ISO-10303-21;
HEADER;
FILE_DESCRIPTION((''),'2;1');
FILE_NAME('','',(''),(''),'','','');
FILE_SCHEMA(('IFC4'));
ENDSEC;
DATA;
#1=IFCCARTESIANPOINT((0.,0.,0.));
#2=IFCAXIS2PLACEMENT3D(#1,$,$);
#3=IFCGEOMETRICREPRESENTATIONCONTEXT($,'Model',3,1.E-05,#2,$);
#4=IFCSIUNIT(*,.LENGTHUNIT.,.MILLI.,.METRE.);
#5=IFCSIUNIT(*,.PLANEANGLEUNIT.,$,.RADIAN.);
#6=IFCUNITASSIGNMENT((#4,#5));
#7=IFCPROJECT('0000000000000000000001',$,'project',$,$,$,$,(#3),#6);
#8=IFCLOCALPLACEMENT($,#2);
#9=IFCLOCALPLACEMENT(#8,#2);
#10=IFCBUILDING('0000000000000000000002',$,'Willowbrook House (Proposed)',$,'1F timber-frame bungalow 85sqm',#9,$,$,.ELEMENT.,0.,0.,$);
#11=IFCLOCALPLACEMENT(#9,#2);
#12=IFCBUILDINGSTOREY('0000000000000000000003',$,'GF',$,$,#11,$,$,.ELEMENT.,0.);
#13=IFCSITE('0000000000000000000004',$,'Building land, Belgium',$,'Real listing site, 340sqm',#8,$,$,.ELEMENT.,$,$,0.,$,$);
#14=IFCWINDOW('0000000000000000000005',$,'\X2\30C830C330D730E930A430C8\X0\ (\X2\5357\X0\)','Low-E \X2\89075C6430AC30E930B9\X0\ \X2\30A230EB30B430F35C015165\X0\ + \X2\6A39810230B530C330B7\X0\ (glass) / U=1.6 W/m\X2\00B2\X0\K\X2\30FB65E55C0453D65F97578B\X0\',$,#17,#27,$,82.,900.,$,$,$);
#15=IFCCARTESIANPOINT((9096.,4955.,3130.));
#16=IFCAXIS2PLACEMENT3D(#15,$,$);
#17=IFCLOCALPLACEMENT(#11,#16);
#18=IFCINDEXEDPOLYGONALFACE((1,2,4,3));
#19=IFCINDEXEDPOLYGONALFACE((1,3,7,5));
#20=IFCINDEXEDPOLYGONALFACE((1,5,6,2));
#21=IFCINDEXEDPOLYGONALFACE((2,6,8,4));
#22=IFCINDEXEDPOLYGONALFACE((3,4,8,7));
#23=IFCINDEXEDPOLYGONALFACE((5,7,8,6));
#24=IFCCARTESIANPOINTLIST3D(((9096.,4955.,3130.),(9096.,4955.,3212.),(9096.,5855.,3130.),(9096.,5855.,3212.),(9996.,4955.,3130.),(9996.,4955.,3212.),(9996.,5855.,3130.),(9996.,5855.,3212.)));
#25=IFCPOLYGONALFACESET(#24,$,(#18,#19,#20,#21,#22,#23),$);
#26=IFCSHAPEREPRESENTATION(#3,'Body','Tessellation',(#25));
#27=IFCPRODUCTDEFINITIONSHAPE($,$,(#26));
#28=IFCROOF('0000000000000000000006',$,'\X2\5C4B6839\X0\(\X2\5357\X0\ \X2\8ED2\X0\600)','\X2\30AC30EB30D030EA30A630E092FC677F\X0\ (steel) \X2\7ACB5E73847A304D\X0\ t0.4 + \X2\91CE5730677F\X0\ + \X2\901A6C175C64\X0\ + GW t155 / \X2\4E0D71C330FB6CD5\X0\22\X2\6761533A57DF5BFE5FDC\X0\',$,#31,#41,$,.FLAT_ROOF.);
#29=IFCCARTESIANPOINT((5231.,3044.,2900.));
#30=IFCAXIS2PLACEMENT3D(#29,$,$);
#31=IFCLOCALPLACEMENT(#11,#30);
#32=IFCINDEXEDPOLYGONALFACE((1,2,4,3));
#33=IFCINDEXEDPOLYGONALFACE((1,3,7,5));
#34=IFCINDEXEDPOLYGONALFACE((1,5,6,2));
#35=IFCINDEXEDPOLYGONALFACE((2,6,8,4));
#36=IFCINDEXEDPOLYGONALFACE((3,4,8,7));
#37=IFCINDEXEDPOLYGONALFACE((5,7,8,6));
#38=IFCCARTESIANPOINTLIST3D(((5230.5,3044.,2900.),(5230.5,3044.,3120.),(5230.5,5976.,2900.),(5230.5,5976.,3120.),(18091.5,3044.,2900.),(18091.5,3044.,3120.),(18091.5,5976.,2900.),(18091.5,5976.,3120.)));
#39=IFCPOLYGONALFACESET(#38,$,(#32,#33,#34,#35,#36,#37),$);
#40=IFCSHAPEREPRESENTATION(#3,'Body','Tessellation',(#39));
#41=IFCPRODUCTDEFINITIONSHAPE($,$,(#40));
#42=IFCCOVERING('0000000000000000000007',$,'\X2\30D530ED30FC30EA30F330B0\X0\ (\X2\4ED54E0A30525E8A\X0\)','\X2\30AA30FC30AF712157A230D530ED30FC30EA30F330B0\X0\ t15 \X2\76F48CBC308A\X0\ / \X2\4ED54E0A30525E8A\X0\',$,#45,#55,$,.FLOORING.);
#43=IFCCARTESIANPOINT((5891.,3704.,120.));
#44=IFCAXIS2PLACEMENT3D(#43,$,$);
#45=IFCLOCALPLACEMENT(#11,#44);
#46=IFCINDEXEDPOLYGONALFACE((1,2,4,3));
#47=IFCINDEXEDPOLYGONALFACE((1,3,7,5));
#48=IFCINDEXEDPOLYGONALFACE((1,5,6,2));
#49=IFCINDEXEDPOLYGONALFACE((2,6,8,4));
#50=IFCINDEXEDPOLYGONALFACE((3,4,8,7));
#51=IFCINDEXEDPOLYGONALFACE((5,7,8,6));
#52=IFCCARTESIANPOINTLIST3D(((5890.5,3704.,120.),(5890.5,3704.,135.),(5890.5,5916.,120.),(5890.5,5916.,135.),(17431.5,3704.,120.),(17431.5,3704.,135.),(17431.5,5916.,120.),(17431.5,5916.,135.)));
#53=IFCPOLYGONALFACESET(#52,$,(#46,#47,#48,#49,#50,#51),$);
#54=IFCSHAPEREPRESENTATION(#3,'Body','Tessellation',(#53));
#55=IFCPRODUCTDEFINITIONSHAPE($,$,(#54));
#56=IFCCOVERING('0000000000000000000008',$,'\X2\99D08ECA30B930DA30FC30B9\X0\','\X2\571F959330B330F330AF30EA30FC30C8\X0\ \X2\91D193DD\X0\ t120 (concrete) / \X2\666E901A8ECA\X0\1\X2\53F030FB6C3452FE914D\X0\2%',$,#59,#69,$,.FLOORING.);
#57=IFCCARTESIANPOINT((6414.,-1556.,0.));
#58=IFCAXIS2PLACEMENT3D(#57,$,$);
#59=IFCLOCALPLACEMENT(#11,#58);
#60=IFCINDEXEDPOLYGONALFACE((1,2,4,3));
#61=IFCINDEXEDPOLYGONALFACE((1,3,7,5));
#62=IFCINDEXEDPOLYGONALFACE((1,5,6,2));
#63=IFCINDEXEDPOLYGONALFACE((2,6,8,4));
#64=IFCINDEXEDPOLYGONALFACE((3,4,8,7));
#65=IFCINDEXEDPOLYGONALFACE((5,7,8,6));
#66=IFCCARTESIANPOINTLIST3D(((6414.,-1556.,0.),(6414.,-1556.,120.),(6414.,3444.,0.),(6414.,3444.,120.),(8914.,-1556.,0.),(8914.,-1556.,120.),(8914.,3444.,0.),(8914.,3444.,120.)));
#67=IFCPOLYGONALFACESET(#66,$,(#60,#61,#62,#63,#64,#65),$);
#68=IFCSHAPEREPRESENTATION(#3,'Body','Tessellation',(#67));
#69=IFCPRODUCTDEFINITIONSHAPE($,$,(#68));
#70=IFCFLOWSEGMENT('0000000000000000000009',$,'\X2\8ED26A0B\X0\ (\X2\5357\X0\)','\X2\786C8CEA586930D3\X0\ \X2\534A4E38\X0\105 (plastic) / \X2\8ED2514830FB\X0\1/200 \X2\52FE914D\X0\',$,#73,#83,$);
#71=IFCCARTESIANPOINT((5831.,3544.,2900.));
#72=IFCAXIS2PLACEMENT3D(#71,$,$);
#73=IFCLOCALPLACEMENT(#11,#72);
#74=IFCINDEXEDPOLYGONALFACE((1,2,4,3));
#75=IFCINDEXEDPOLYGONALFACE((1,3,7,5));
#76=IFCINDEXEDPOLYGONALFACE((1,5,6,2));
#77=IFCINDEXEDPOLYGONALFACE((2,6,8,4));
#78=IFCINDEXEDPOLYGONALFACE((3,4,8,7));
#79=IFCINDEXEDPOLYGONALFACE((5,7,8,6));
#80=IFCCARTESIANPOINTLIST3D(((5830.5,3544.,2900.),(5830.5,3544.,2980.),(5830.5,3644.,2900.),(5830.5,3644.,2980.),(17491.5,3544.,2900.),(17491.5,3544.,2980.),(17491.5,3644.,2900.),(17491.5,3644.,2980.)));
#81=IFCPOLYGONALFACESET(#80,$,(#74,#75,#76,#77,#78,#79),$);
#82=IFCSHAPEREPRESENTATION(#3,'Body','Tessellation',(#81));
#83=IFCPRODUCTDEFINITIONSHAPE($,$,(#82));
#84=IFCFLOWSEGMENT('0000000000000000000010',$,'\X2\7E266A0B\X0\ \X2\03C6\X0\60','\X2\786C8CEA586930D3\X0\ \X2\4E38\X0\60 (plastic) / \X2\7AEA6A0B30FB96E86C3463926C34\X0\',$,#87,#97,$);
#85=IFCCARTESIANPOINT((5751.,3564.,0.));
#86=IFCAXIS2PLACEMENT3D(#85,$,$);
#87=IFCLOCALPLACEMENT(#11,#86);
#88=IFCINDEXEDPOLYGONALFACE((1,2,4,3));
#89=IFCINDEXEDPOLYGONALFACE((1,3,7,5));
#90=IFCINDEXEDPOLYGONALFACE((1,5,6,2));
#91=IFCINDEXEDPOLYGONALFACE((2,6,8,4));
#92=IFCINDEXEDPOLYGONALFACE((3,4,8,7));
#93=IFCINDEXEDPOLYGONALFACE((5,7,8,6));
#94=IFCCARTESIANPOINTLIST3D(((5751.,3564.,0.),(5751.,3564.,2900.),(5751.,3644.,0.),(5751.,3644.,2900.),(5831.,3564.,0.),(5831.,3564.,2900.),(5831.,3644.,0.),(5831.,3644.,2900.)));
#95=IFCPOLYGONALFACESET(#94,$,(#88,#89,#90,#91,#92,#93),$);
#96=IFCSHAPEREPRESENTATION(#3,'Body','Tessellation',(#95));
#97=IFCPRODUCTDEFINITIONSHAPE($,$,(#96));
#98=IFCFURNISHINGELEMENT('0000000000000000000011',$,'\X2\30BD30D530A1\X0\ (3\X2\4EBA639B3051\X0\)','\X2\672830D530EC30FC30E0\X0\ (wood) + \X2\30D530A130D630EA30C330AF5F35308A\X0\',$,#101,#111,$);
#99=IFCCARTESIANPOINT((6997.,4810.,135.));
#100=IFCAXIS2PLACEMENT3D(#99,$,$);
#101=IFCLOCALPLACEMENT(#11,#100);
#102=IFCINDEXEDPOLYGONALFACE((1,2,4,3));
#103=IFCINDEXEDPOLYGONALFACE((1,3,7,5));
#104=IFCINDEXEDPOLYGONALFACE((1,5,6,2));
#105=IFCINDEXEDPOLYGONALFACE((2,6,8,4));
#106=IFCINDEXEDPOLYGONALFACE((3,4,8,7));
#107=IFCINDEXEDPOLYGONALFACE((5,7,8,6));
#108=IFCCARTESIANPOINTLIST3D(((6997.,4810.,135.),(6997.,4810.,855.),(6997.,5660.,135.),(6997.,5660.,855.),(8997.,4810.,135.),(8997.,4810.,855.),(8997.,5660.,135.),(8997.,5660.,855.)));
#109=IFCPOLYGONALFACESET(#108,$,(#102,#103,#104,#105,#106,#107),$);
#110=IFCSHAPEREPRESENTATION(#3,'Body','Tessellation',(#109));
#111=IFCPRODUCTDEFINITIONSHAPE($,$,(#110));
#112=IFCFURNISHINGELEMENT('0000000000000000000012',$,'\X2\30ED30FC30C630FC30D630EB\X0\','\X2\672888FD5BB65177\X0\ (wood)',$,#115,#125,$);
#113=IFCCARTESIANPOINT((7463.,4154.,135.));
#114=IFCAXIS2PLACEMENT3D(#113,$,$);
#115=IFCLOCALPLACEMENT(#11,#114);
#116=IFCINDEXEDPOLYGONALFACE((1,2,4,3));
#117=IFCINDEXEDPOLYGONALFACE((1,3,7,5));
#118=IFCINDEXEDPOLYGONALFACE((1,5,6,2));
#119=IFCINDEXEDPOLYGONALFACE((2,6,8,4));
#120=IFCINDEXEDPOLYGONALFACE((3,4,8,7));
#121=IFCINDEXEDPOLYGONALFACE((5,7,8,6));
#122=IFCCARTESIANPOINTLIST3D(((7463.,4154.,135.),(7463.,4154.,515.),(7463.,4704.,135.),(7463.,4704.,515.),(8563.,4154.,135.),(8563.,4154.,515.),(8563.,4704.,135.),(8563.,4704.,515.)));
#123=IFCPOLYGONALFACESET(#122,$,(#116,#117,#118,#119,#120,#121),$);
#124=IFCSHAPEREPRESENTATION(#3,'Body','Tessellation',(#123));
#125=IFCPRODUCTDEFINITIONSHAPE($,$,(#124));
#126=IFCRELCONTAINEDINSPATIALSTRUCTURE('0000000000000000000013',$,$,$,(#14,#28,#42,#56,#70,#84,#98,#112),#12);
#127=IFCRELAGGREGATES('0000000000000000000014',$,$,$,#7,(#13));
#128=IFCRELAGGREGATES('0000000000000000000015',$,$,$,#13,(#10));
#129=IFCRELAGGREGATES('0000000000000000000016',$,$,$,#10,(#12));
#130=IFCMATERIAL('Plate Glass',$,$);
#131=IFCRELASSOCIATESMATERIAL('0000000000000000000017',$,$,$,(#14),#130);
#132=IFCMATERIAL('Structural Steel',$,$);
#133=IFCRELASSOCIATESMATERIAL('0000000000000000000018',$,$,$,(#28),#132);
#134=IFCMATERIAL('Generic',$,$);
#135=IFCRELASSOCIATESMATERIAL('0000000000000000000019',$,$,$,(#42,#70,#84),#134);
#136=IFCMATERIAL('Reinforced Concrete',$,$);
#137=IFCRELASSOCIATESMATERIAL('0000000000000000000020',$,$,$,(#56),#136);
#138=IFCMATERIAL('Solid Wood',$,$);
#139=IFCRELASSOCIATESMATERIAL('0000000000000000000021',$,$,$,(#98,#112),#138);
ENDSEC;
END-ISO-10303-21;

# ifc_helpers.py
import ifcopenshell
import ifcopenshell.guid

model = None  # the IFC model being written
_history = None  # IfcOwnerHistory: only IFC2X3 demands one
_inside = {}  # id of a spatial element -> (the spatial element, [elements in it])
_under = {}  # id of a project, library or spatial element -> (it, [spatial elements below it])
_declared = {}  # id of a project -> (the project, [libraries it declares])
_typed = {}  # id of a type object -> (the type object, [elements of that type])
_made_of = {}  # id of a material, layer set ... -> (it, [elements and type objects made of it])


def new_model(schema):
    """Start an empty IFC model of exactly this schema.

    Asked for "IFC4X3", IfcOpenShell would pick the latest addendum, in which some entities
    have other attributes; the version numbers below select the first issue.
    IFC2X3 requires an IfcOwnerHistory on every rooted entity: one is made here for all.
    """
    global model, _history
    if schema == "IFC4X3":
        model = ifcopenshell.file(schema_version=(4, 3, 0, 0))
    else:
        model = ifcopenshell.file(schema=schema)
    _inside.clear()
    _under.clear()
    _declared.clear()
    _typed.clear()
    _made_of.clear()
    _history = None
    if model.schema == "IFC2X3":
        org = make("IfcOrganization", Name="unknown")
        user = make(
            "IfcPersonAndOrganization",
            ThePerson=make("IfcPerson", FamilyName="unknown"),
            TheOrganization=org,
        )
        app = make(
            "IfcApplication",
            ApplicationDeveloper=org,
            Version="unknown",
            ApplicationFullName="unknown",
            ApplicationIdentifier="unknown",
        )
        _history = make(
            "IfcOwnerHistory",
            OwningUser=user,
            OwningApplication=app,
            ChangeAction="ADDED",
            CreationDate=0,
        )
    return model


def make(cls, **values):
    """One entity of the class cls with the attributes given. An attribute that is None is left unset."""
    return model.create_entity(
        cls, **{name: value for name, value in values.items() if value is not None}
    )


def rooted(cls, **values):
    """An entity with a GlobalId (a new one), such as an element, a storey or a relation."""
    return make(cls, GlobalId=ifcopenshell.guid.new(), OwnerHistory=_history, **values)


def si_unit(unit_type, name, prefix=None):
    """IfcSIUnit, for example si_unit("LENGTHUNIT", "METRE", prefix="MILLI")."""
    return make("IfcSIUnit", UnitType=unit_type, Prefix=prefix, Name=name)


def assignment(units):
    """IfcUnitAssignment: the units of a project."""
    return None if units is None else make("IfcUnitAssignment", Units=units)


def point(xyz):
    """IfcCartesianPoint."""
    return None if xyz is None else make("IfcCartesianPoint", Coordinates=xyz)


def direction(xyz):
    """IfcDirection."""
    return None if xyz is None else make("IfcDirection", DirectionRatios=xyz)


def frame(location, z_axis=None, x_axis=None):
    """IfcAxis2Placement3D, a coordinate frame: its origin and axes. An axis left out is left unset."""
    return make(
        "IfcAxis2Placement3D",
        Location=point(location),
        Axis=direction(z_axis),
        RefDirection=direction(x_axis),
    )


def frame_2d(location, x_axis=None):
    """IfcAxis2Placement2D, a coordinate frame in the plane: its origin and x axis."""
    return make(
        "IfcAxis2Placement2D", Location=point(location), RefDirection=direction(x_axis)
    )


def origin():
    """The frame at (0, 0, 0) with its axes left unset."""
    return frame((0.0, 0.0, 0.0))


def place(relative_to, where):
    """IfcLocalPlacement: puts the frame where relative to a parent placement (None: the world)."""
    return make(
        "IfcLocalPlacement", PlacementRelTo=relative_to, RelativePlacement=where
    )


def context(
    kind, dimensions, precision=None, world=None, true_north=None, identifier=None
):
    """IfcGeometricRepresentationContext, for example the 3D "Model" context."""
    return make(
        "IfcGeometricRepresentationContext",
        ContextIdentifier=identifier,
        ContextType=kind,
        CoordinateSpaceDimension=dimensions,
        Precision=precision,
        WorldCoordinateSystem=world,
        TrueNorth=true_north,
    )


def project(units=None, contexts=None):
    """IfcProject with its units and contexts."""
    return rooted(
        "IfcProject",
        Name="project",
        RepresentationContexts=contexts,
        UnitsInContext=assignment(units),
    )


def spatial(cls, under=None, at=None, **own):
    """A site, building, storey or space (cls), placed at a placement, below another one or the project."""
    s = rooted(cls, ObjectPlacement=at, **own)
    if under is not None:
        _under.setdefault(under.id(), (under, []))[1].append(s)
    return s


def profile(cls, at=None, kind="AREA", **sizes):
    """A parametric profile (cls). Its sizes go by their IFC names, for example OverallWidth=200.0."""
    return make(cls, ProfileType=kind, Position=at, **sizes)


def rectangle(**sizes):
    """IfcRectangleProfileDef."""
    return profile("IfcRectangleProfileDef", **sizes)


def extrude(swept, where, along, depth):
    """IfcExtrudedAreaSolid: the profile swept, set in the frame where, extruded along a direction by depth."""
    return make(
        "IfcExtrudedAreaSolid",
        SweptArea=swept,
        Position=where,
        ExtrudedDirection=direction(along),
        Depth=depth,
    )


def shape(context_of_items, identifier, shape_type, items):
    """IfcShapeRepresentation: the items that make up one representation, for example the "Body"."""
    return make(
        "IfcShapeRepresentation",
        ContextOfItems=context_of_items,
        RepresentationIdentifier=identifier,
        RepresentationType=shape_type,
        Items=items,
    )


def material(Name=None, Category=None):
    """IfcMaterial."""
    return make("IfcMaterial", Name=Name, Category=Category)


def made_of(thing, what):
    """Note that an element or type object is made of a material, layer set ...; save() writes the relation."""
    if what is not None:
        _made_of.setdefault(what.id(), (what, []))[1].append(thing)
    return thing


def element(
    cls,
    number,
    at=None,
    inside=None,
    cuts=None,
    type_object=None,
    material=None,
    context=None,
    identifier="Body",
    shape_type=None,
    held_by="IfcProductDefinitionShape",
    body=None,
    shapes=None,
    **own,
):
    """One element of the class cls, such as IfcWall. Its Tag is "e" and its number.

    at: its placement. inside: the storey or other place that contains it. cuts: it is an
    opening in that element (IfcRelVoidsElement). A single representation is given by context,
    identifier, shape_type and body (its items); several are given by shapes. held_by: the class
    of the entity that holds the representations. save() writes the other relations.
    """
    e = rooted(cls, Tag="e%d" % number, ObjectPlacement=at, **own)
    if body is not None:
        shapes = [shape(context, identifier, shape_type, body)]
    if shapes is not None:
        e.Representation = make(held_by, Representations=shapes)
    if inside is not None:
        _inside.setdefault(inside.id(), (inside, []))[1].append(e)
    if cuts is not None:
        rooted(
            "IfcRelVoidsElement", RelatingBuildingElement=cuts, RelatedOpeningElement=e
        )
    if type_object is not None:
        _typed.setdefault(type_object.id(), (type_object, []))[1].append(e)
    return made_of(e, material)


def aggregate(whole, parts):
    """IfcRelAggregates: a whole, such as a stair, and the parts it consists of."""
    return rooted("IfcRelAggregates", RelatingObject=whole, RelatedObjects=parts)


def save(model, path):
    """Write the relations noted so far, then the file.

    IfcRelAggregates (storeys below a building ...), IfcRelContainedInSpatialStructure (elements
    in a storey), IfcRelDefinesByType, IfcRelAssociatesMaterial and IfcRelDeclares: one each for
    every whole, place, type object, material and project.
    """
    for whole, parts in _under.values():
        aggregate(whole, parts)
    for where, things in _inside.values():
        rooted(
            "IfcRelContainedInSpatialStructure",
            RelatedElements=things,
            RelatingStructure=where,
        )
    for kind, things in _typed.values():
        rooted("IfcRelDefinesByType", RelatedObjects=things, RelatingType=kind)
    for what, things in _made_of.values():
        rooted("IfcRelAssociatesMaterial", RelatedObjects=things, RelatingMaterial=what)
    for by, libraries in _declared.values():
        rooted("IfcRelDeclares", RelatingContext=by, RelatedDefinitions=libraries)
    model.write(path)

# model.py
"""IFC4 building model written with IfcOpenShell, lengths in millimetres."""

from ifc_helpers import new_model, si_unit, frame, frame_2d, origin, place, context, project, spatial, rectangle, extrude, material, element, save


model = new_model("IFC4")

# Units and contexts
model_context = context("Model", 3, precision=1e-05, world=origin())
ifc_project = project(units=[si_unit("LENGTHUNIT", "METRE", prefix="MILLI"), si_unit("PLANEANGLEUNIT", "RADIAN")], contexts=[model_context])

# Site, building, storey
site_placement = place(None, origin())
site = spatial("IfcSite", under=ifc_project, at=site_placement, Name="Building land, Belgium", ObjectType="Real listing site, 340sqm", CompositionType="ELEMENT", RefElevation=0.0)
building_placement = place(site_placement, origin())
building = spatial("IfcBuilding", under=site, at=building_placement, Name="Willowbrook House (Proposed)", ObjectType="1F timber-frame bungalow 85sqm", CompositionType="ELEMENT", ElevationOfRefHeight=0.0, ElevationOfTerrain=0.0)
storey_placement = place(building_placement, origin())
storey = spatial("IfcBuildingStorey", under=building, at=storey_placement, Name="GF", CompositionType="ELEMENT", Elevation=0.0)

# Shared definitions
ifc_material_1 = material(Name="Solid Wood")

# Shared definitions
ifc_material_2 = material(Name="Reinforced Concrete")

# Shared definitions
ifc_material_3 = material(Name="Plate Glass")

# Window
window_1_placement = place(storey_placement, frame((9096.0, 4955.0, 3130.0)))
element("IfcWindow", 1, at=window_1_placement, inside=storey, material=ifc_material_3, Name="トップライト (南)", Description="Low-E 複層ガラス アルゴン封入 + 樹脂サッシ (glass) / U=1.6 W/m²K・日射取得型", OverallHeight=82.0, OverallWidth=900.0, context=model_context, shape_type="SweptSolid", body=[
    extrude(rectangle(XDim=900.0, YDim=900.0, at=frame_2d((450.0, 450.0))), frame((9096.0, 4955.0, 3130.0)), (0.0, 0.0, 1.0), 82.0),
])

# Roof
ifc_material_4 = material(Name="Structural Steel")
roof_1_placement = place(storey_placement, frame((5231.0, 3044.0, 2900.0)))
element("IfcRoof", 2, at=roof_1_placement, inside=storey, material=ifc_material_4, Name="屋根(南 軒600)", Description="ガルバリウム鋼板 (steel) 立平葺き t0.4 + 野地板 + 通気層 + GW t155 / 不燃・法22条区域対応", PredefinedType="FLAT_ROOF", context=model_context, shape_type="SweptSolid", body=[
    extrude(rectangle(XDim=12861.0, YDim=2932.0, at=frame_2d((6430.0, 1466.0))), frame((5231.0, 3044.0, 2900.0)), (0.0, 0.0, 1.0), 220.0),
])

# Coverings
ifc_material_5 = material(Name="Generic")
covering_1_placement = place(storey_placement, frame((5891.0, 3704.0, 120.0)))
element("IfcCovering", 3, at=covering_1_placement, inside=storey, material=ifc_material_5, Name="フローリング (仕上げ床)", Description="オーク無垢フローリング t15 直貼り / 仕上げ床", PredefinedType="FLOORING", context=model_context, shape_type="SweptSolid", body=[
    extrude(rectangle(XDim=11541.0, YDim=2212.0, at=frame_2d((5770.0, 1106.0))), frame((5891.0, 3704.0, 120.0)), (0.0, 0.0, 1.0), 15.0),
])
covering_2_placement = place(storey_placement, frame((6414.0, -1556.0, 0.0)))
element("IfcCovering", 4, at=covering_2_placement, inside=storey, material=ifc_material_2, Name="駐車スペース", Description="土間コンクリート 金鏝 t120 (concrete) / 普通車1台・水勾配2%", PredefinedType="FLOORING", context=model_context, shape_type="SweptSolid", body=[
    extrude(rectangle(XDim=2500.0, YDim=5000.0, at=frame_2d((1250.0, 2500.0))), frame((6414.0, -1556.0, 0.0)), (0.0, 0.0, 1.0), 120.0),
])

# Flow segments
flow_segment_1_placement = place(storey_placement, frame((5831.0, 3544.0, 2900.0)))
element("IfcFlowSegment", 5, at=flow_segment_1_placement, inside=storey, material=ifc_material_5, Name="軒樋 (南)", Description="硬質塩ビ 半丸105 (plastic) / 軒先・1/200 勾配", context=model_context, shape_type="SweptSolid", body=[
    extrude(rectangle(XDim=11661.0, YDim=100.0, at=frame_2d((5830.0, 50.0))), frame((5831.0, 3544.0, 2900.0)), (0.0, 0.0, 1.0), 80.0),
])
flow_segment_2_placement = place(storey_placement, frame((5751.0, 3564.0, 0.0)))
element("IfcFlowSegment", 6, at=flow_segment_2_placement, inside=storey, material=ifc_material_5, Name="縦樋 φ60", Description="硬質塩ビ 丸60 (plastic) / 竪樋・雨水排水", context=model_context, shape_type="SweptSolid", body=[
    extrude(rectangle(XDim=80.0, YDim=80.0, at=frame_2d((40.0, 40.0))), frame((5751.0, 3564.0, 0.0)), (0.0, 0.0, 1.0), 2900.0),
])

# Furnishing elements
furnishing_1_placement = place(storey_placement, frame((6997.0, 4810.0, 135.0)))
element("IfcFurnishingElement", 7, at=furnishing_1_placement, inside=storey, material=ifc_material_1, Name="ソファ (3人掛け)", Description="木フレーム (wood) + ファブリック張り", context=model_context, shape_type="SweptSolid", body=[
    extrude(rectangle(XDim=2000.0, YDim=850.0, at=frame_2d((1000.0, 425.0))), frame((6997.0, 4810.0, 135.0)), (0.0, 0.0, 1.0), 720.0),
])
furnishing_2_placement = place(storey_placement, frame((7463.0, 4154.0, 135.0)))
element("IfcFurnishingElement", 8, at=furnishing_2_placement, inside=storey, material=ifc_material_1, Name="ローテーブル", Description="木製家具 (wood)", context=model_context, shape_type="SweptSolid", body=[
    extrude(rectangle(XDim=1100.0, YDim=550.0, at=frame_2d((550.0, 275.0))), frame((7463.0, 4154.0, 135.0)), (0.0, 0.0, 1.0), 380.0),
])

save(model, "model.ifc")
